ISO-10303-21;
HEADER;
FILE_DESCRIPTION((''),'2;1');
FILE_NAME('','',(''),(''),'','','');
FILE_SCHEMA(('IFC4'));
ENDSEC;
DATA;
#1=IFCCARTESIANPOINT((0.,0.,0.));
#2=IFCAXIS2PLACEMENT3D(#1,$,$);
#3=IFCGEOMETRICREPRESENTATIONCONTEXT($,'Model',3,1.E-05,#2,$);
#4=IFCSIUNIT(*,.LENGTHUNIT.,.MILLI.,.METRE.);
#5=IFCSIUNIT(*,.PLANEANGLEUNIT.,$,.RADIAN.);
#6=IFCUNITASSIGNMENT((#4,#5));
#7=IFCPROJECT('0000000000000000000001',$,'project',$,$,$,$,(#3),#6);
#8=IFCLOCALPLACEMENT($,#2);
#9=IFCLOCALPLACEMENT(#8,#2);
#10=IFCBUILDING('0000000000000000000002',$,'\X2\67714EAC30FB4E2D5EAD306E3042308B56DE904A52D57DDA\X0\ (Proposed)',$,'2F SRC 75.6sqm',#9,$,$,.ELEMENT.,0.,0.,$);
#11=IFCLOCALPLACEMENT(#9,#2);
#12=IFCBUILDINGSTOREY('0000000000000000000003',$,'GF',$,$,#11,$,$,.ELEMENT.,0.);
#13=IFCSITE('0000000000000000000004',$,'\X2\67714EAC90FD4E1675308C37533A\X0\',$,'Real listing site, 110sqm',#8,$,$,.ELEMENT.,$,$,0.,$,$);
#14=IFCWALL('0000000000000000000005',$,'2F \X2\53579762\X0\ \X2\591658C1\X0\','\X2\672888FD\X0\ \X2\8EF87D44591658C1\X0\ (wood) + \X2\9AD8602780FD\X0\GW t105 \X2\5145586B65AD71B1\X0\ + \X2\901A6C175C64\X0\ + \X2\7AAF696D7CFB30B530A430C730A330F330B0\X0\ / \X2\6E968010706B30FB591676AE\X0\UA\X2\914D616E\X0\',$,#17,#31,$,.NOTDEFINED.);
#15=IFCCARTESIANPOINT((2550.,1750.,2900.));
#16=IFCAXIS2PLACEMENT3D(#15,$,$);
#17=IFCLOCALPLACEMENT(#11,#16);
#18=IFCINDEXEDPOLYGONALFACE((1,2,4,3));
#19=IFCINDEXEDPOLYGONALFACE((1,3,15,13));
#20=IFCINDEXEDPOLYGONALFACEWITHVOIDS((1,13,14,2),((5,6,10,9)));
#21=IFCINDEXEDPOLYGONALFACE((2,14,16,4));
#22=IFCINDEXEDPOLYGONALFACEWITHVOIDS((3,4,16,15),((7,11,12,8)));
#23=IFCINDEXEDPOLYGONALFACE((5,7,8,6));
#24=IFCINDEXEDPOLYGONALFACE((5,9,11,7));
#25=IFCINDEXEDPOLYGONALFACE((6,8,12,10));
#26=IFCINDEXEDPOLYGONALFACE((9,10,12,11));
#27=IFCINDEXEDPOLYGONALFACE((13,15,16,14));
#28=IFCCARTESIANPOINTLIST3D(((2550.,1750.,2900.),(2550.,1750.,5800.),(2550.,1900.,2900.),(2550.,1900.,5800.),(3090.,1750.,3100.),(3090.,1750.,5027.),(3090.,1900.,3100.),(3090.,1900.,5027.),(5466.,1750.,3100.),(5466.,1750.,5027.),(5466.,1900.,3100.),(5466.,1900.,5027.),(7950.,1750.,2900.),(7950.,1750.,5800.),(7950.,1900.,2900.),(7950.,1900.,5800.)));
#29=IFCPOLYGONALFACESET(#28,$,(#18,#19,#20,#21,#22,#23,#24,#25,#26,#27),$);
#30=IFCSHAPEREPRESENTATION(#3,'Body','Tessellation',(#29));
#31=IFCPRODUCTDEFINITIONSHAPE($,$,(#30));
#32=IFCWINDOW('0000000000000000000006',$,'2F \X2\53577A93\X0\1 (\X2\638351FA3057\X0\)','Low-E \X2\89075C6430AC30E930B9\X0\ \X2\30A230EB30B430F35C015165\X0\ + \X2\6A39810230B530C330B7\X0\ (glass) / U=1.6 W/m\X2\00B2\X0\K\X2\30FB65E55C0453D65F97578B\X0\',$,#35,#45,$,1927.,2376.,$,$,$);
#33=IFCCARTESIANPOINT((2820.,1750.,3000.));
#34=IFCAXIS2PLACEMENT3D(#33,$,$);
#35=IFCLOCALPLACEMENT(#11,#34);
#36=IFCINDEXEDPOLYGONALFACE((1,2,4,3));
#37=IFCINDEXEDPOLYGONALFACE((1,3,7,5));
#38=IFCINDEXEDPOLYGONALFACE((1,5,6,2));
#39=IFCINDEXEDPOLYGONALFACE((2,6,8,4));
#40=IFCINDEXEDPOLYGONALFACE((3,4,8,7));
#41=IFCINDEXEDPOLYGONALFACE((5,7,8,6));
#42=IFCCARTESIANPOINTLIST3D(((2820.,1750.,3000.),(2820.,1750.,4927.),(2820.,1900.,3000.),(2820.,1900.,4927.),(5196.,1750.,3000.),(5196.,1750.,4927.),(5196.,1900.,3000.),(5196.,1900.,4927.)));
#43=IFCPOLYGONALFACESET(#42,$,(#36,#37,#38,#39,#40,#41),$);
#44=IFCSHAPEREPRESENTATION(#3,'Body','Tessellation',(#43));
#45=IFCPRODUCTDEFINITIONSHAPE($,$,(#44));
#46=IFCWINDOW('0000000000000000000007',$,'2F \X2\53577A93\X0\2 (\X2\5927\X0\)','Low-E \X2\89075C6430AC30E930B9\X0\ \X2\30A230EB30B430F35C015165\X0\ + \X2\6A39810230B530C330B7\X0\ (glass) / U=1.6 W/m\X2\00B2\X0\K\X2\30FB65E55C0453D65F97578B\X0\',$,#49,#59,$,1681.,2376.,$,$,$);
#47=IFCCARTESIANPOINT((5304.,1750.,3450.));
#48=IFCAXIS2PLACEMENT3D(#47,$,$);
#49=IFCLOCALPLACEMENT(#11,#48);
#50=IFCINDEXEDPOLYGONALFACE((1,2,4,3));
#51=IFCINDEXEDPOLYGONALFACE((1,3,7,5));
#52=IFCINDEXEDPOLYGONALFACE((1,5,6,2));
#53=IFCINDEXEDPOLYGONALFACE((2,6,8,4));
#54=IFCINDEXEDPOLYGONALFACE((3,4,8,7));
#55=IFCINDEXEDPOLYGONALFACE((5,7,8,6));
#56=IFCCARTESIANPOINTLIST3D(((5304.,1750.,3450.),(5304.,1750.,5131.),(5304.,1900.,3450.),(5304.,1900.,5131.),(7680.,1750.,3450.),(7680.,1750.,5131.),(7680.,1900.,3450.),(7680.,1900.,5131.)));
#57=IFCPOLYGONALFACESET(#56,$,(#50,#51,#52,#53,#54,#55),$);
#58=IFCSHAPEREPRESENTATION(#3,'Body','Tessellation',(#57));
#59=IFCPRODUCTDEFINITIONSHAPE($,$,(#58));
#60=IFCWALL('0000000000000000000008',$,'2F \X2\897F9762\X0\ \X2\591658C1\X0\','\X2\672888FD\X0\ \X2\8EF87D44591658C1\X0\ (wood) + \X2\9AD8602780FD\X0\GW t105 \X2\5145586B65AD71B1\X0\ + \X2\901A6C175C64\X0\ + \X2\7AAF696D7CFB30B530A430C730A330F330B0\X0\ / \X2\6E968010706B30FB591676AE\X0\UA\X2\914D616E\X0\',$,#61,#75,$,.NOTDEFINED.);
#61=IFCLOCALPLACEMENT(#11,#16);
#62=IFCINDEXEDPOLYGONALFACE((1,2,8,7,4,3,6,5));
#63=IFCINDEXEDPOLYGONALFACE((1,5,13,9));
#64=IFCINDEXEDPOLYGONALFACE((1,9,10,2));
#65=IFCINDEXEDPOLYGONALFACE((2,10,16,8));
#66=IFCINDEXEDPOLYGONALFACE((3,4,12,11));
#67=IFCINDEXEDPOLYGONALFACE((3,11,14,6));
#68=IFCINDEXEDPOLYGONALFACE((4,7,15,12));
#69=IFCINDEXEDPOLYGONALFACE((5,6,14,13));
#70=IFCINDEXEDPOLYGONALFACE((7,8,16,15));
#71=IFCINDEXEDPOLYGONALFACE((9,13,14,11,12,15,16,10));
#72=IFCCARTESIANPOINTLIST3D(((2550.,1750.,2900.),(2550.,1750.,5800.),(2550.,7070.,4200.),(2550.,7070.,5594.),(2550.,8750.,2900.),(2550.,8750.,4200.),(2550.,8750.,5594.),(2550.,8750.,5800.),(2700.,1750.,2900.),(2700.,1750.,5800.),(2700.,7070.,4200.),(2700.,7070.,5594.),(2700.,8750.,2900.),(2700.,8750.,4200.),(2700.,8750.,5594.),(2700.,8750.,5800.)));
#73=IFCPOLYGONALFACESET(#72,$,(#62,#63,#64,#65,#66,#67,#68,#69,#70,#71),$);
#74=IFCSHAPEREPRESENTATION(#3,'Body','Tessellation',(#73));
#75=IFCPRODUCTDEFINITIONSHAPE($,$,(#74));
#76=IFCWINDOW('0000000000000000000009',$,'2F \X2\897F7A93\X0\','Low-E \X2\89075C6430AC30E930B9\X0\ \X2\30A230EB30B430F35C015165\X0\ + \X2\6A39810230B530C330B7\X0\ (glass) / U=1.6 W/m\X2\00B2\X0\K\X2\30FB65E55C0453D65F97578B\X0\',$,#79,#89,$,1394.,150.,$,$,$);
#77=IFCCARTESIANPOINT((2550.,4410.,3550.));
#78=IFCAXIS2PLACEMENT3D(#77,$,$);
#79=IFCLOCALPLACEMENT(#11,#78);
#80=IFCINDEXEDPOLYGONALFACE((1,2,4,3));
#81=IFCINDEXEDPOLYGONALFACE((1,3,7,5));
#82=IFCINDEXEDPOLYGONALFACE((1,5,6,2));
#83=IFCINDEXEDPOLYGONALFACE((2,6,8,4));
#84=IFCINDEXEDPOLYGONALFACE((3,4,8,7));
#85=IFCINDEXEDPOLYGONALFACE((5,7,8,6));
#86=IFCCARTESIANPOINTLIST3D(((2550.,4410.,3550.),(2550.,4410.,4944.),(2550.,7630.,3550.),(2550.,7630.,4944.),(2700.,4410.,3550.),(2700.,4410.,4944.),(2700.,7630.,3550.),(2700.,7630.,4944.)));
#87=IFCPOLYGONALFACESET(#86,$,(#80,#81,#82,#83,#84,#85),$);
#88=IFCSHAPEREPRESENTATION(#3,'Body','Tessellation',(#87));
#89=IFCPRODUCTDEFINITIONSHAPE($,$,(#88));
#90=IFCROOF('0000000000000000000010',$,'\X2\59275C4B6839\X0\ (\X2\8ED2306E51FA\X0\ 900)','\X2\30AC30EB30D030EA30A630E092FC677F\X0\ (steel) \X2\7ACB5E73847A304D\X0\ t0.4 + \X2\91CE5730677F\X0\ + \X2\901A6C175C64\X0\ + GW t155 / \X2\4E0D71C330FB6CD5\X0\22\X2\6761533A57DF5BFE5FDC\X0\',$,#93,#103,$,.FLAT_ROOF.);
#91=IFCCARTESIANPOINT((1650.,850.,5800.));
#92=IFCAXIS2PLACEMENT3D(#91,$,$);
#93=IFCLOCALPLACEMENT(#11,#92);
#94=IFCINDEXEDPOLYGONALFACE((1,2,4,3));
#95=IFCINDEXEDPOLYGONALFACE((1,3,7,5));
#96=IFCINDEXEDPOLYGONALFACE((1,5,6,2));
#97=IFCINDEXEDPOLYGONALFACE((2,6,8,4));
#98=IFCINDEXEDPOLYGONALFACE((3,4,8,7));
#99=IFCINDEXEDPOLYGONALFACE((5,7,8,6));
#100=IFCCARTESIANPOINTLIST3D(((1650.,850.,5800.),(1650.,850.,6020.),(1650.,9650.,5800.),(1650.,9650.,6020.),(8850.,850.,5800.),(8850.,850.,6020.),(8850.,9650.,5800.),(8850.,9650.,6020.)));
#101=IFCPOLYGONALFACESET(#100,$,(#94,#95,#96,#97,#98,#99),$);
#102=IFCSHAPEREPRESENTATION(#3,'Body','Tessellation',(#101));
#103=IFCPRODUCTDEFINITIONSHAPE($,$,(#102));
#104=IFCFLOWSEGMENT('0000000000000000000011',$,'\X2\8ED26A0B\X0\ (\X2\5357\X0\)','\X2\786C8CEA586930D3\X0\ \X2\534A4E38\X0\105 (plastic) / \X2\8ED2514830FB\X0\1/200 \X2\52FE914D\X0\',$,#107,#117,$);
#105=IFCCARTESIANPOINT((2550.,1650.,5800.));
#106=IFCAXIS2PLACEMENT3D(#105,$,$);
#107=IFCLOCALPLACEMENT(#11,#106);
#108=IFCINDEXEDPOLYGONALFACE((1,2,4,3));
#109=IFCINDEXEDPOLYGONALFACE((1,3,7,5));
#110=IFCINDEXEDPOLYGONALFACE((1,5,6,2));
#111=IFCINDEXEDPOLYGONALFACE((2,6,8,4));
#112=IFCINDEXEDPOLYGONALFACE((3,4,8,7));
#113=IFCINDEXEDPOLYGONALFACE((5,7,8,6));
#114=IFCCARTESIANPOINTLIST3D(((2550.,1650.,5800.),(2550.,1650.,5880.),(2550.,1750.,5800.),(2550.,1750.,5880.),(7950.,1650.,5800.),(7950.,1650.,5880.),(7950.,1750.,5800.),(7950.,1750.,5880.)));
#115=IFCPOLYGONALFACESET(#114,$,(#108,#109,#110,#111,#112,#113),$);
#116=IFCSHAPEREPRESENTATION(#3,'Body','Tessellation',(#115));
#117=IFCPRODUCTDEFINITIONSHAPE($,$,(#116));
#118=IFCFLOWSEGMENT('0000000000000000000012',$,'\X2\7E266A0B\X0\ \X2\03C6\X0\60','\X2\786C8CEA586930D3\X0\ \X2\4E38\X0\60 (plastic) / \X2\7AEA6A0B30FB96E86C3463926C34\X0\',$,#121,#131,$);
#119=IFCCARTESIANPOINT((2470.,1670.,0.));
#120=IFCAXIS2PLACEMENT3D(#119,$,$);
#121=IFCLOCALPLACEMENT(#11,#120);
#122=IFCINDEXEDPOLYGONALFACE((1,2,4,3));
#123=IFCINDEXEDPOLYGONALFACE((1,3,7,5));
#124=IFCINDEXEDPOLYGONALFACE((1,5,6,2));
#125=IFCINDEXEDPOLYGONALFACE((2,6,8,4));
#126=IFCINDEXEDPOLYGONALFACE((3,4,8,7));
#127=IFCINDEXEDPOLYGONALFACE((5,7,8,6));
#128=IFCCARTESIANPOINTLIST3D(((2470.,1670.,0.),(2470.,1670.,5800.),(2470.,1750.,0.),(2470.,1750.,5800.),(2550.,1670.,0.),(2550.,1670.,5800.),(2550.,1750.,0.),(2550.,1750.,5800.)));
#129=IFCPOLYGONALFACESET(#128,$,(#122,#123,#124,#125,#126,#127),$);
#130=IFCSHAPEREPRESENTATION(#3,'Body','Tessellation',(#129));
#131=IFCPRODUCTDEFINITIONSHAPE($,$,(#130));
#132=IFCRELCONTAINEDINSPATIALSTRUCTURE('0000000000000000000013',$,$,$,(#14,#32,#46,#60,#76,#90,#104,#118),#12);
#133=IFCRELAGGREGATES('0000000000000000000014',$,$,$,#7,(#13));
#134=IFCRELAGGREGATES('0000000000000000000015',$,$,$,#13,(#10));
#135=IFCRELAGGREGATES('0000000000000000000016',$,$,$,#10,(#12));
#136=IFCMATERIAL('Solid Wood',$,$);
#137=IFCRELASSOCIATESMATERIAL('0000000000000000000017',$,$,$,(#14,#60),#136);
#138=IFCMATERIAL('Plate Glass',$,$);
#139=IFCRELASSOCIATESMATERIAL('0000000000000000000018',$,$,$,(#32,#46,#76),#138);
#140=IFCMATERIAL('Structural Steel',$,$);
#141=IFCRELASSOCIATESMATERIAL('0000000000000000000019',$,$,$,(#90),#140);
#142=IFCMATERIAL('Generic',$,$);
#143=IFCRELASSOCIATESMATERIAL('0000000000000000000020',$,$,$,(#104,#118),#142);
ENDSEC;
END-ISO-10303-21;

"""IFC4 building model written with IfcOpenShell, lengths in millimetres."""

from ifc_helpers import new_model, si_unit, frame, frame_2d, origin, place, context, project, spatial, rectangle, extrude, material, element, fill, save


model = new_model("IFC4")

# Units and contexts
model_context = context("Model", 3, precision=1e-05, world=origin())
ifc_project = project(units=[si_unit("LENGTHUNIT", "METRE", prefix="MILLI"), si_unit("PLANEANGLEUNIT", "RADIAN")], contexts=[model_context])

# Site, building, storey
site_placement = place(None, origin())
site = spatial("IfcSite", under=ifc_project, at=site_placement, Name="東京都世田谷区", ObjectType="Real listing site, 110sqm", CompositionType="ELEMENT", RefElevation=0.0)
building_placement = place(site_placement, origin())
building = spatial("IfcBuilding", under=site, at=building_placement, Name="東京・中庭のある回遊動線 (Proposed)", ObjectType="2F SRC 75.6sqm", CompositionType="ELEMENT", ElevationOfRefHeight=0.0, ElevationOfTerrain=0.0)
storey_placement = place(building_placement, origin())
storey = spatial("IfcBuildingStorey", under=building, at=storey_placement, Name="GF", CompositionType="ELEMENT", Elevation=0.0)

# Shared definitions
ifc_material_1 = material(Name="Solid Wood")

# Shared definitions
ifc_material_2 = material(Name="Plate Glass")

# Wall, openings, windows
wall_1_placement = place(storey_placement, frame((2550.0, 1750.0, 2900.0)))
wall_1 = element("IfcWall", 1, at=wall_1_placement, inside=storey, material=ifc_material_1, Name="2F 南面 外壁", Description="木製 軸組外壁 (wood) + 高性能GW t105 充填断熱 + 通気層 + 窯業系サイディング / 準耐火・外皮UA配慮", PredefinedType="NOTDEFINED", context=model_context, shape_type="SweptSolid", body=[
    extrude(rectangle(XDim=5400.0, YDim=150.0, at=frame_2d((2700.0, 75.0))), frame((2550.0, 1750.0, 2900.0)), (0.0, 0.0, 1.0), 2900.0),
])
opening_1_placement = place(storey_placement, frame((2820.0, 1750.0, 3000.0)))
opening_1 = element("IfcOpeningElement", 2, at=opening_1_placement, cuts=wall_1, PredefinedType="NOTDEFINED", context=model_context, shape_type="SweptSolid", body=[
    extrude(rectangle(XDim=2376.0, YDim=150.0, at=frame_2d((1188.0, 75.0))), frame((2820.0, 1750.0, 3000.0)), (0.0, 0.0, 1.0), 1927.0),
])
opening_2_placement = place(storey_placement, frame((5304.0, 1750.0, 3450.0)))
opening_2 = element("IfcOpeningElement", 3, at=opening_2_placement, cuts=wall_1, PredefinedType="NOTDEFINED", context=model_context, shape_type="SweptSolid", body=[
    extrude(rectangle(XDim=2376.0, YDim=150.0, at=frame_2d((1188.0, 75.0))), frame((5304.0, 1750.0, 3450.0)), (0.0, 0.0, 1.0), 1681.0),
])
window_1_placement = place(storey_placement, frame((2820.0, 1750.0, 3000.0)))
window_1 = element("IfcWindow", 4, at=window_1_placement, inside=storey, material=ifc_material_2, Name="2F 南窓1 (掃出し)", Description="Low-E 複層ガラス アルゴン封入 + 樹脂サッシ (glass) / U=1.6 W/m²K・日射取得型", OverallHeight=1927.0, OverallWidth=2376.0, context=model_context, shape_type="SweptSolid", body=[
    extrude(rectangle(XDim=2376.0, YDim=150.0, at=frame_2d((1188.0, 75.0))), frame((2820.0, 1750.0, 3000.0)), (0.0, 0.0, 1.0), 1927.0),
])
fill(opening_1, window_1)
window_2_placement = place(storey_placement, frame((5304.0, 1750.0, 3450.0)))
window_2 = element("IfcWindow", 5, at=window_2_placement, inside=storey, material=ifc_material_2, Name="2F 南窓2 (大)", Description="Low-E 複層ガラス アルゴン封入 + 樹脂サッシ (glass) / U=1.6 W/m²K・日射取得型", OverallHeight=1681.0, OverallWidth=2376.0, context=model_context, shape_type="SweptSolid", body=[
    extrude(rectangle(XDim=2376.0, YDim=150.0, at=frame_2d((1188.0, 75.0))), frame((5304.0, 1750.0, 3450.0)), (0.0, 0.0, 1.0), 1681.0),
])
fill(opening_2, window_2)

# Wall, opening, window
wall_2_placement = place(storey_placement, frame((2550.0, 1750.0, 2900.0)))
wall_2 = element("IfcWall", 6, at=wall_2_placement, inside=storey, material=ifc_material_1, Name="2F 西面 外壁", Description="木製 軸組外壁 (wood) + 高性能GW t105 充填断熱 + 通気層 + 窯業系サイディング / 準耐火・外皮UA配慮", PredefinedType="NOTDEFINED", context=model_context, shape_type="SweptSolid", body=[
    extrude(rectangle(XDim=150.0, YDim=7000.0, at=frame_2d((75.0, 3500.0))), frame((2550.0, 1750.0, 2900.0)), (0.0, 0.0, 1.0), 2900.0),
])
opening_3_placement = place(storey_placement, frame((2550.0, 4410.0, 3550.0)))
opening_3 = element("IfcOpeningElement", 7, at=opening_3_placement, cuts=wall_2, PredefinedType="NOTDEFINED", context=model_context, shape_type="SweptSolid", body=[
    extrude(rectangle(XDim=150.0, YDim=3220.0, at=frame_2d((75.0, 1610.0))), frame((2550.0, 4410.0, 3550.0)), (0.0, 0.0, 1.0), 1394.0),
])
window_3_placement = place(storey_placement, frame((2550.0, 4410.0, 3550.0)))
window_3 = element("IfcWindow", 8, at=window_3_placement, inside=storey, material=ifc_material_2, Name="2F 西窓", Description="Low-E 複層ガラス アルゴン封入 + 樹脂サッシ (glass) / U=1.6 W/m²K・日射取得型", OverallHeight=1394.0, OverallWidth=150.0, context=model_context, shape_type="SweptSolid", body=[
    extrude(rectangle(XDim=150.0, YDim=3220.0, at=frame_2d((75.0, 1610.0))), frame((2550.0, 4410.0, 3550.0)), (0.0, 0.0, 1.0), 1394.0),
])
fill(opening_3, window_3)

# Roof
ifc_material_3 = material(Name="Structural Steel")
roof_placement = place(storey_placement, frame((1650.0, 850.0, 5800.0)))
element("IfcRoof", 9, at=roof_placement, inside=storey, material=ifc_material_3, Name="大屋根 (軒の出 900)", Description="ガルバリウム鋼板 (steel) 立平葺き t0.4 + 野地板 + 通気層 + GW t155 / 不燃・法22条区域対応", PredefinedType="FLAT_ROOF", context=model_context, shape_type="SweptSolid", body=[
    extrude(rectangle(XDim=7200.0, YDim=8800.0, at=frame_2d((3600.0, 4400.0))), frame((1650.0, 850.0, 5800.0)), (0.0, 0.0, 1.0), 220.0),
])

# Flow segments
ifc_material_4 = material(Name="Generic")
flow_segment_1_placement = place(storey_placement, frame((2550.0, 1650.0, 5800.0)))
element("IfcFlowSegment", 10, at=flow_segment_1_placement, inside=storey, material=ifc_material_4, Name="軒樋 (南)", Description="硬質塩ビ 半丸105 (plastic) / 軒先・1/200 勾配", context=model_context, shape_type="SweptSolid", body=[
    extrude(rectangle(XDim=5400.0, YDim=100.0, at=frame_2d((2700.0, 50.0))), frame((2550.0, 1650.0, 5800.0)), (0.0, 0.0, 1.0), 80.0),
])
flow_segment_2_placement = place(storey_placement, frame((2470.0, 1670.0, 0.0)))
element("IfcFlowSegment", 11, at=flow_segment_2_placement, inside=storey, material=ifc_material_4, Name="縦樋 φ60", Description="硬質塩ビ 丸60 (plastic) / 竪樋・雨水排水", context=model_context, shape_type="SweptSolid", body=[
    extrude(rectangle(XDim=80.0, YDim=80.0, at=frame_2d((40.0, 40.0))), frame((2470.0, 1670.0, 0.0)), (0.0, 0.0, 1.0), 5800.0),
])

save(model, "model.ifc")
